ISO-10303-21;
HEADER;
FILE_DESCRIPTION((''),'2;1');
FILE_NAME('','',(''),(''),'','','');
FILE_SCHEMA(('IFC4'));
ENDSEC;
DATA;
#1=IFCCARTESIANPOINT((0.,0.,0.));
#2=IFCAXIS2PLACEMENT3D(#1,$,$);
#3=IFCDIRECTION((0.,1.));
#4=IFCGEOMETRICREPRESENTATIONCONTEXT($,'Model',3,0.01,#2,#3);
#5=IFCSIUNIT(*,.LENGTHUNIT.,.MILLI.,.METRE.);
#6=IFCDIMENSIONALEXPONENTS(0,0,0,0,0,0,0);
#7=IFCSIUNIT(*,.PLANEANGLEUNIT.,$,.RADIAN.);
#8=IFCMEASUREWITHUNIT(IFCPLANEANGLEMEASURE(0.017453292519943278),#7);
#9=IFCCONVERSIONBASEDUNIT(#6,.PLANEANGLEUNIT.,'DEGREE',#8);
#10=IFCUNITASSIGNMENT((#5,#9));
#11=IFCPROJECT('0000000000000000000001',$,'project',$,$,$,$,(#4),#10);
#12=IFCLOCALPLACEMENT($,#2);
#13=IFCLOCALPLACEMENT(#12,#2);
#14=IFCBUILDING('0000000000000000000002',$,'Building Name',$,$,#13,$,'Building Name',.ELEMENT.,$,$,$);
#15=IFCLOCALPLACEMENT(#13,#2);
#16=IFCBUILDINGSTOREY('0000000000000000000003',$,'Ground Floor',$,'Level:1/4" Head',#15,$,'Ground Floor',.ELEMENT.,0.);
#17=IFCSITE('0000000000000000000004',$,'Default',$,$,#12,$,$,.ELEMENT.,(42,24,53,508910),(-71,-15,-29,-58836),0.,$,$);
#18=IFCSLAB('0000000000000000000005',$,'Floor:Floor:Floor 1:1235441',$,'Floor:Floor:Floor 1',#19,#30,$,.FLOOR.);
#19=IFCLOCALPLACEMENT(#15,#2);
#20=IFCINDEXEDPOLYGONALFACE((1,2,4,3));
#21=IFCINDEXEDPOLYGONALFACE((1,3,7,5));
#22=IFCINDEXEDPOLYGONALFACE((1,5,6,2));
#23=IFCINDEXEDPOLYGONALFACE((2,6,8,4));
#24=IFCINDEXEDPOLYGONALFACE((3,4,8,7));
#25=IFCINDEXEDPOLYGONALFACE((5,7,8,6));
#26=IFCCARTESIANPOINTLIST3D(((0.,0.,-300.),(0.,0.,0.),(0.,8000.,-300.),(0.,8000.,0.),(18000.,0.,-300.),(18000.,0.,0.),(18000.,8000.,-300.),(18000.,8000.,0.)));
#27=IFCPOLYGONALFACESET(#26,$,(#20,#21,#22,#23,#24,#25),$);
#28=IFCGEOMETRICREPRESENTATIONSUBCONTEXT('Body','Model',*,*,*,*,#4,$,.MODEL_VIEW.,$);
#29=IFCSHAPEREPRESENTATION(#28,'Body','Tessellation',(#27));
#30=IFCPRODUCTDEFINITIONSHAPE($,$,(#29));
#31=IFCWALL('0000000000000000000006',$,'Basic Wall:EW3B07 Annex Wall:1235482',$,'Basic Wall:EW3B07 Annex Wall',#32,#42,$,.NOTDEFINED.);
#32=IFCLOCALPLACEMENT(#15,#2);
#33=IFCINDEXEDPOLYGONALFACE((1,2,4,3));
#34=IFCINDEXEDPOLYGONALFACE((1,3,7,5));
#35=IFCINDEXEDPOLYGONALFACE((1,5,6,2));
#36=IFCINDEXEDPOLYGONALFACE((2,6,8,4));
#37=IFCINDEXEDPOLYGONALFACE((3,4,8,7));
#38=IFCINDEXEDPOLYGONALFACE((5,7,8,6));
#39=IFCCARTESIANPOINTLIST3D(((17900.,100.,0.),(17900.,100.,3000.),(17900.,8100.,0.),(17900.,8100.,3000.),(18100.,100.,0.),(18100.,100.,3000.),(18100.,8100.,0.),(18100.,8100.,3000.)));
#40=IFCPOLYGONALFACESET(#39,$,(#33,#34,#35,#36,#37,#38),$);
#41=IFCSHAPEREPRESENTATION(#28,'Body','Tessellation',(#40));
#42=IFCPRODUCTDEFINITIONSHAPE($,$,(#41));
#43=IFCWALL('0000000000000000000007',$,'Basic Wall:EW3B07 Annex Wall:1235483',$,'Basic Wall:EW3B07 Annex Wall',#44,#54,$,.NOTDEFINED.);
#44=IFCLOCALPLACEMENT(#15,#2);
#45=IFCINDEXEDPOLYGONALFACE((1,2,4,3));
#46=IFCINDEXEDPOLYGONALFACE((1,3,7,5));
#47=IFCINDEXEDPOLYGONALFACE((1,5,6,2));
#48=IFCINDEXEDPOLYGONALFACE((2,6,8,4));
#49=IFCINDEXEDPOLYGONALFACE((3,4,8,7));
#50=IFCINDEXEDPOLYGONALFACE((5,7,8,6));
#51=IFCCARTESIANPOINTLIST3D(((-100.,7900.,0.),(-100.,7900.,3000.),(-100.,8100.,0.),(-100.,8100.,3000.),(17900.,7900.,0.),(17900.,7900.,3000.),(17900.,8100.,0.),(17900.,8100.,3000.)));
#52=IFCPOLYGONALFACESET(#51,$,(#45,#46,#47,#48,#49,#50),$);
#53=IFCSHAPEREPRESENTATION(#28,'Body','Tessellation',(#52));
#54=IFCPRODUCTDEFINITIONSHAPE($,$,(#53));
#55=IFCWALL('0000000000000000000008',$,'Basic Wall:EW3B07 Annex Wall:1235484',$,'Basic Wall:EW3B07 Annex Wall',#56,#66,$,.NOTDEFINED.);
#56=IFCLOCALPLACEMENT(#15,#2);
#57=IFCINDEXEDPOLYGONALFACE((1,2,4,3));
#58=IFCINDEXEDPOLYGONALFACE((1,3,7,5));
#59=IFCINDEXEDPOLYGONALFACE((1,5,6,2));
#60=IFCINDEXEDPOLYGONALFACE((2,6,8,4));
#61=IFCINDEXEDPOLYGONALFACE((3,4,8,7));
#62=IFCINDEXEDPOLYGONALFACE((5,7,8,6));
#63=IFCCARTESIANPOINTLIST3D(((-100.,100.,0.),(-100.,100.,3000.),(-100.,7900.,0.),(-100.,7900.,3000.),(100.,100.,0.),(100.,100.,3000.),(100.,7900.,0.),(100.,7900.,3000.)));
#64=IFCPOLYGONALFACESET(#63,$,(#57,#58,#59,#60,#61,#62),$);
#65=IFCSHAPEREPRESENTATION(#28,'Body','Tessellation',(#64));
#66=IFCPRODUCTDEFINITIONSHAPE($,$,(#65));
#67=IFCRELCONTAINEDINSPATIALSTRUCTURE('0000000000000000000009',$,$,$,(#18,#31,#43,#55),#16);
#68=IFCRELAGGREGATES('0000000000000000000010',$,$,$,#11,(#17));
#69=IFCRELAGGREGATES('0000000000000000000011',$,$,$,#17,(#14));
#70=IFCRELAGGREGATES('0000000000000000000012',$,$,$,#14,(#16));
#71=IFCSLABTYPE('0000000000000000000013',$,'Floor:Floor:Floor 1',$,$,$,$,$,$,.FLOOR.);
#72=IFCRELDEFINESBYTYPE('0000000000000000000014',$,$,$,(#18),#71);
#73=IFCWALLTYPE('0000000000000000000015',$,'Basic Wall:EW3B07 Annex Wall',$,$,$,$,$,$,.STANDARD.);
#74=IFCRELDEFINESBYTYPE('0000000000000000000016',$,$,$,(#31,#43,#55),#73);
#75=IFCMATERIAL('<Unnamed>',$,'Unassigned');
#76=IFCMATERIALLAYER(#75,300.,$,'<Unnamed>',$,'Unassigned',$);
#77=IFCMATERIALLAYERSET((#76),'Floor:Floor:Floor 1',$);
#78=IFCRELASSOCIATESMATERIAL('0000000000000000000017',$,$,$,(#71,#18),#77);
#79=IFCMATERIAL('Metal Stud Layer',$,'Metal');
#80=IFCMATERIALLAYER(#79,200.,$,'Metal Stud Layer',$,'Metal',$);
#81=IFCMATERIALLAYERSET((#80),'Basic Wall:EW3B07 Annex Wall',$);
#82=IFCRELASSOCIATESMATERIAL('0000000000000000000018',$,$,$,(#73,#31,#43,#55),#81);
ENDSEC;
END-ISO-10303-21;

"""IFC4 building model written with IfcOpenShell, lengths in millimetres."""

from ifc_helpers import new_model, entity, si_unit, converted_unit, direction, frame, frame_2d, origin, origin_2d_with_axis, place, context, subcontext, project, spatial, rectangle, extrude, material, layer, layer_set, layer_usage, type_object, element, save


model = new_model("IFC4")

# Units and contexts
model_context = context("Model", 3, precision=0.01, world=origin(), true_north=direction((0.0, 1.0)))
body_context = subcontext(model_context, "Body", "Model", "MODEL_VIEW")
ifc_project = project(units=[si_unit("LENGTHUNIT", "METRE", prefix="MILLI"), converted_unit("PLANEANGLEUNIT", "DEGREE", entity("IfcPlaneAngleMeasure", 0.017453292519943278), si_unit("PLANEANGLEUNIT", "RADIAN"), dimensions=[0, 0, 0, 0, 0, 0, 0])], contexts=[model_context])

# Site, building, storey
site_placement = place(None, origin())
site = spatial("IfcSite", under=ifc_project, at=site_placement, Name="Default", CompositionType="ELEMENT", RefLatitude=(42, 24, 53, 508910), RefLongitude=(-71, -15, -29, -58836), RefElevation=0.0)
building_placement = place(site_placement, origin())
building = spatial("IfcBuilding", under=site, at=building_placement, Name="Building Name", LongName="Building Name", CompositionType="ELEMENT")
storey_placement = place(building_placement, origin())
storey = spatial("IfcBuildingStorey", under=building, at=storey_placement, Name="Ground Floor", ObjectType="Level:1/4\" Head", LongName="Ground Floor", CompositionType="ELEMENT", Elevation=0.0)

# Slab
ifc_material_1 = material(Name="<Unnamed>", Category="Unassigned")
ifc_layer_1 = layer(ifc_material_1, 300.0, Name="<Unnamed>", Category="Unassigned")
ifc_layer_set_1 = layer_set([ifc_layer_1], Name="Floor:Floor:Floor 1")
ifc_layer_usage_1 = layer_usage(ifc_layer_set_1, "AXIS3", "POSITIVE", 0.0)
slab_type = type_object("IfcSlabType", Name="Floor:Floor:Floor 1", PredefinedType="FLOOR", material=ifc_layer_set_1)
slab_placement = place(storey_placement, origin())
element("IfcSlab", 1, at=slab_placement, inside=storey, type_object=slab_type, material=ifc_layer_usage_1, Name="Floor:Floor:Floor 1:1235441", ObjectType="Floor:Floor:Floor 1", PredefinedType="FLOOR", context=body_context, shape_type="SweptSolid", body=[
    extrude(rectangle(XDim=8000.0, YDim=18000.0, at=origin_2d_with_axis()), frame((9000.0, 4000.0, 0.0), z_axis=(0.0, 0.0, -1.0), x_axis=(0.0, 1.0, 0.0)), (0.0, 0.0, 1.0), 300.0),
])

# Shared definitions
ifc_material_2 = material(Name="Metal Stud Layer", Category="Metal")
ifc_layer_2 = layer(ifc_material_2, 200.0, Name="Metal Stud Layer", Category="Metal")
ifc_layer_set_2 = layer_set([ifc_layer_2], Name="Basic Wall:EW3B07 Annex Wall")
wall_type = type_object("IfcWallType", Name="Basic Wall:EW3B07 Annex Wall", PredefinedType="STANDARD", material=ifc_layer_set_2)

# Walls
ifc_layer_usage_2 = layer_usage(ifc_layer_set_2, "AXIS2", "NEGATIVE", 100.0)
wall_1_placement = place(storey_placement, frame((18000.0, 100.0, 0.0), z_axis=(0.0, 0.0, 1.0), x_axis=(0.0, 1.0, 0.0)))
element("IfcWall", 2, at=wall_1_placement, inside=storey, type_object=wall_type, material=ifc_layer_usage_2, Name="Basic Wall:EW3B07 Annex Wall:1235482", ObjectType="Basic Wall:EW3B07 Annex Wall", PredefinedType="NOTDEFINED", context=body_context, shape_type="SweptSolid", body=[
    extrude(rectangle(XDim=8000.0, YDim=200.0, at=frame_2d((4000.0, 0.0), x_axis=(-1.0, 0.0))), origin(), (0.0, 0.0, 1.0), 3000.0),
])
ifc_layer_usage_3 = layer_usage(ifc_layer_set_2, "AXIS2", "NEGATIVE", 100.0)
wall_2_placement = place(storey_placement, frame((17900.0, 8000.0, 0.0), z_axis=(0.0, 0.0, 1.0), x_axis=(-1.0, 0.0, 0.0)))
element("IfcWall", 3, at=wall_2_placement, inside=storey, type_object=wall_type, material=ifc_layer_usage_3, Name="Basic Wall:EW3B07 Annex Wall:1235483", ObjectType="Basic Wall:EW3B07 Annex Wall", PredefinedType="NOTDEFINED", context=body_context, shape_type="SweptSolid", body=[
    extrude(rectangle(XDim=18000.0, YDim=200.0, at=frame_2d((9000.0, 0.0), x_axis=(-1.0, 0.0))), origin(), (0.0, 0.0, 1.0), 3000.0),
])
ifc_layer_usage_4 = layer_usage(ifc_layer_set_2, "AXIS2", "NEGATIVE", 100.0)
wall_3_placement = place(storey_placement, frame((0.0, 7900.0, 0.0), z_axis=(0.0, 0.0, 1.0), x_axis=(0.0, -1.0, 0.0)))
element("IfcWall", 4, at=wall_3_placement, inside=storey, type_object=wall_type, material=ifc_layer_usage_4, Name="Basic Wall:EW3B07 Annex Wall:1235484", ObjectType="Basic Wall:EW3B07 Annex Wall", PredefinedType="NOTDEFINED", context=body_context, shape_type="SweptSolid", body=[
    extrude(rectangle(XDim=7800.0, YDim=200.0, at=frame_2d((3900.0, 0.0), x_axis=(-1.0, 0.0))), origin(), (0.0, 0.0, 1.0), 3000.0),
])

save(model, "model.ifc")
